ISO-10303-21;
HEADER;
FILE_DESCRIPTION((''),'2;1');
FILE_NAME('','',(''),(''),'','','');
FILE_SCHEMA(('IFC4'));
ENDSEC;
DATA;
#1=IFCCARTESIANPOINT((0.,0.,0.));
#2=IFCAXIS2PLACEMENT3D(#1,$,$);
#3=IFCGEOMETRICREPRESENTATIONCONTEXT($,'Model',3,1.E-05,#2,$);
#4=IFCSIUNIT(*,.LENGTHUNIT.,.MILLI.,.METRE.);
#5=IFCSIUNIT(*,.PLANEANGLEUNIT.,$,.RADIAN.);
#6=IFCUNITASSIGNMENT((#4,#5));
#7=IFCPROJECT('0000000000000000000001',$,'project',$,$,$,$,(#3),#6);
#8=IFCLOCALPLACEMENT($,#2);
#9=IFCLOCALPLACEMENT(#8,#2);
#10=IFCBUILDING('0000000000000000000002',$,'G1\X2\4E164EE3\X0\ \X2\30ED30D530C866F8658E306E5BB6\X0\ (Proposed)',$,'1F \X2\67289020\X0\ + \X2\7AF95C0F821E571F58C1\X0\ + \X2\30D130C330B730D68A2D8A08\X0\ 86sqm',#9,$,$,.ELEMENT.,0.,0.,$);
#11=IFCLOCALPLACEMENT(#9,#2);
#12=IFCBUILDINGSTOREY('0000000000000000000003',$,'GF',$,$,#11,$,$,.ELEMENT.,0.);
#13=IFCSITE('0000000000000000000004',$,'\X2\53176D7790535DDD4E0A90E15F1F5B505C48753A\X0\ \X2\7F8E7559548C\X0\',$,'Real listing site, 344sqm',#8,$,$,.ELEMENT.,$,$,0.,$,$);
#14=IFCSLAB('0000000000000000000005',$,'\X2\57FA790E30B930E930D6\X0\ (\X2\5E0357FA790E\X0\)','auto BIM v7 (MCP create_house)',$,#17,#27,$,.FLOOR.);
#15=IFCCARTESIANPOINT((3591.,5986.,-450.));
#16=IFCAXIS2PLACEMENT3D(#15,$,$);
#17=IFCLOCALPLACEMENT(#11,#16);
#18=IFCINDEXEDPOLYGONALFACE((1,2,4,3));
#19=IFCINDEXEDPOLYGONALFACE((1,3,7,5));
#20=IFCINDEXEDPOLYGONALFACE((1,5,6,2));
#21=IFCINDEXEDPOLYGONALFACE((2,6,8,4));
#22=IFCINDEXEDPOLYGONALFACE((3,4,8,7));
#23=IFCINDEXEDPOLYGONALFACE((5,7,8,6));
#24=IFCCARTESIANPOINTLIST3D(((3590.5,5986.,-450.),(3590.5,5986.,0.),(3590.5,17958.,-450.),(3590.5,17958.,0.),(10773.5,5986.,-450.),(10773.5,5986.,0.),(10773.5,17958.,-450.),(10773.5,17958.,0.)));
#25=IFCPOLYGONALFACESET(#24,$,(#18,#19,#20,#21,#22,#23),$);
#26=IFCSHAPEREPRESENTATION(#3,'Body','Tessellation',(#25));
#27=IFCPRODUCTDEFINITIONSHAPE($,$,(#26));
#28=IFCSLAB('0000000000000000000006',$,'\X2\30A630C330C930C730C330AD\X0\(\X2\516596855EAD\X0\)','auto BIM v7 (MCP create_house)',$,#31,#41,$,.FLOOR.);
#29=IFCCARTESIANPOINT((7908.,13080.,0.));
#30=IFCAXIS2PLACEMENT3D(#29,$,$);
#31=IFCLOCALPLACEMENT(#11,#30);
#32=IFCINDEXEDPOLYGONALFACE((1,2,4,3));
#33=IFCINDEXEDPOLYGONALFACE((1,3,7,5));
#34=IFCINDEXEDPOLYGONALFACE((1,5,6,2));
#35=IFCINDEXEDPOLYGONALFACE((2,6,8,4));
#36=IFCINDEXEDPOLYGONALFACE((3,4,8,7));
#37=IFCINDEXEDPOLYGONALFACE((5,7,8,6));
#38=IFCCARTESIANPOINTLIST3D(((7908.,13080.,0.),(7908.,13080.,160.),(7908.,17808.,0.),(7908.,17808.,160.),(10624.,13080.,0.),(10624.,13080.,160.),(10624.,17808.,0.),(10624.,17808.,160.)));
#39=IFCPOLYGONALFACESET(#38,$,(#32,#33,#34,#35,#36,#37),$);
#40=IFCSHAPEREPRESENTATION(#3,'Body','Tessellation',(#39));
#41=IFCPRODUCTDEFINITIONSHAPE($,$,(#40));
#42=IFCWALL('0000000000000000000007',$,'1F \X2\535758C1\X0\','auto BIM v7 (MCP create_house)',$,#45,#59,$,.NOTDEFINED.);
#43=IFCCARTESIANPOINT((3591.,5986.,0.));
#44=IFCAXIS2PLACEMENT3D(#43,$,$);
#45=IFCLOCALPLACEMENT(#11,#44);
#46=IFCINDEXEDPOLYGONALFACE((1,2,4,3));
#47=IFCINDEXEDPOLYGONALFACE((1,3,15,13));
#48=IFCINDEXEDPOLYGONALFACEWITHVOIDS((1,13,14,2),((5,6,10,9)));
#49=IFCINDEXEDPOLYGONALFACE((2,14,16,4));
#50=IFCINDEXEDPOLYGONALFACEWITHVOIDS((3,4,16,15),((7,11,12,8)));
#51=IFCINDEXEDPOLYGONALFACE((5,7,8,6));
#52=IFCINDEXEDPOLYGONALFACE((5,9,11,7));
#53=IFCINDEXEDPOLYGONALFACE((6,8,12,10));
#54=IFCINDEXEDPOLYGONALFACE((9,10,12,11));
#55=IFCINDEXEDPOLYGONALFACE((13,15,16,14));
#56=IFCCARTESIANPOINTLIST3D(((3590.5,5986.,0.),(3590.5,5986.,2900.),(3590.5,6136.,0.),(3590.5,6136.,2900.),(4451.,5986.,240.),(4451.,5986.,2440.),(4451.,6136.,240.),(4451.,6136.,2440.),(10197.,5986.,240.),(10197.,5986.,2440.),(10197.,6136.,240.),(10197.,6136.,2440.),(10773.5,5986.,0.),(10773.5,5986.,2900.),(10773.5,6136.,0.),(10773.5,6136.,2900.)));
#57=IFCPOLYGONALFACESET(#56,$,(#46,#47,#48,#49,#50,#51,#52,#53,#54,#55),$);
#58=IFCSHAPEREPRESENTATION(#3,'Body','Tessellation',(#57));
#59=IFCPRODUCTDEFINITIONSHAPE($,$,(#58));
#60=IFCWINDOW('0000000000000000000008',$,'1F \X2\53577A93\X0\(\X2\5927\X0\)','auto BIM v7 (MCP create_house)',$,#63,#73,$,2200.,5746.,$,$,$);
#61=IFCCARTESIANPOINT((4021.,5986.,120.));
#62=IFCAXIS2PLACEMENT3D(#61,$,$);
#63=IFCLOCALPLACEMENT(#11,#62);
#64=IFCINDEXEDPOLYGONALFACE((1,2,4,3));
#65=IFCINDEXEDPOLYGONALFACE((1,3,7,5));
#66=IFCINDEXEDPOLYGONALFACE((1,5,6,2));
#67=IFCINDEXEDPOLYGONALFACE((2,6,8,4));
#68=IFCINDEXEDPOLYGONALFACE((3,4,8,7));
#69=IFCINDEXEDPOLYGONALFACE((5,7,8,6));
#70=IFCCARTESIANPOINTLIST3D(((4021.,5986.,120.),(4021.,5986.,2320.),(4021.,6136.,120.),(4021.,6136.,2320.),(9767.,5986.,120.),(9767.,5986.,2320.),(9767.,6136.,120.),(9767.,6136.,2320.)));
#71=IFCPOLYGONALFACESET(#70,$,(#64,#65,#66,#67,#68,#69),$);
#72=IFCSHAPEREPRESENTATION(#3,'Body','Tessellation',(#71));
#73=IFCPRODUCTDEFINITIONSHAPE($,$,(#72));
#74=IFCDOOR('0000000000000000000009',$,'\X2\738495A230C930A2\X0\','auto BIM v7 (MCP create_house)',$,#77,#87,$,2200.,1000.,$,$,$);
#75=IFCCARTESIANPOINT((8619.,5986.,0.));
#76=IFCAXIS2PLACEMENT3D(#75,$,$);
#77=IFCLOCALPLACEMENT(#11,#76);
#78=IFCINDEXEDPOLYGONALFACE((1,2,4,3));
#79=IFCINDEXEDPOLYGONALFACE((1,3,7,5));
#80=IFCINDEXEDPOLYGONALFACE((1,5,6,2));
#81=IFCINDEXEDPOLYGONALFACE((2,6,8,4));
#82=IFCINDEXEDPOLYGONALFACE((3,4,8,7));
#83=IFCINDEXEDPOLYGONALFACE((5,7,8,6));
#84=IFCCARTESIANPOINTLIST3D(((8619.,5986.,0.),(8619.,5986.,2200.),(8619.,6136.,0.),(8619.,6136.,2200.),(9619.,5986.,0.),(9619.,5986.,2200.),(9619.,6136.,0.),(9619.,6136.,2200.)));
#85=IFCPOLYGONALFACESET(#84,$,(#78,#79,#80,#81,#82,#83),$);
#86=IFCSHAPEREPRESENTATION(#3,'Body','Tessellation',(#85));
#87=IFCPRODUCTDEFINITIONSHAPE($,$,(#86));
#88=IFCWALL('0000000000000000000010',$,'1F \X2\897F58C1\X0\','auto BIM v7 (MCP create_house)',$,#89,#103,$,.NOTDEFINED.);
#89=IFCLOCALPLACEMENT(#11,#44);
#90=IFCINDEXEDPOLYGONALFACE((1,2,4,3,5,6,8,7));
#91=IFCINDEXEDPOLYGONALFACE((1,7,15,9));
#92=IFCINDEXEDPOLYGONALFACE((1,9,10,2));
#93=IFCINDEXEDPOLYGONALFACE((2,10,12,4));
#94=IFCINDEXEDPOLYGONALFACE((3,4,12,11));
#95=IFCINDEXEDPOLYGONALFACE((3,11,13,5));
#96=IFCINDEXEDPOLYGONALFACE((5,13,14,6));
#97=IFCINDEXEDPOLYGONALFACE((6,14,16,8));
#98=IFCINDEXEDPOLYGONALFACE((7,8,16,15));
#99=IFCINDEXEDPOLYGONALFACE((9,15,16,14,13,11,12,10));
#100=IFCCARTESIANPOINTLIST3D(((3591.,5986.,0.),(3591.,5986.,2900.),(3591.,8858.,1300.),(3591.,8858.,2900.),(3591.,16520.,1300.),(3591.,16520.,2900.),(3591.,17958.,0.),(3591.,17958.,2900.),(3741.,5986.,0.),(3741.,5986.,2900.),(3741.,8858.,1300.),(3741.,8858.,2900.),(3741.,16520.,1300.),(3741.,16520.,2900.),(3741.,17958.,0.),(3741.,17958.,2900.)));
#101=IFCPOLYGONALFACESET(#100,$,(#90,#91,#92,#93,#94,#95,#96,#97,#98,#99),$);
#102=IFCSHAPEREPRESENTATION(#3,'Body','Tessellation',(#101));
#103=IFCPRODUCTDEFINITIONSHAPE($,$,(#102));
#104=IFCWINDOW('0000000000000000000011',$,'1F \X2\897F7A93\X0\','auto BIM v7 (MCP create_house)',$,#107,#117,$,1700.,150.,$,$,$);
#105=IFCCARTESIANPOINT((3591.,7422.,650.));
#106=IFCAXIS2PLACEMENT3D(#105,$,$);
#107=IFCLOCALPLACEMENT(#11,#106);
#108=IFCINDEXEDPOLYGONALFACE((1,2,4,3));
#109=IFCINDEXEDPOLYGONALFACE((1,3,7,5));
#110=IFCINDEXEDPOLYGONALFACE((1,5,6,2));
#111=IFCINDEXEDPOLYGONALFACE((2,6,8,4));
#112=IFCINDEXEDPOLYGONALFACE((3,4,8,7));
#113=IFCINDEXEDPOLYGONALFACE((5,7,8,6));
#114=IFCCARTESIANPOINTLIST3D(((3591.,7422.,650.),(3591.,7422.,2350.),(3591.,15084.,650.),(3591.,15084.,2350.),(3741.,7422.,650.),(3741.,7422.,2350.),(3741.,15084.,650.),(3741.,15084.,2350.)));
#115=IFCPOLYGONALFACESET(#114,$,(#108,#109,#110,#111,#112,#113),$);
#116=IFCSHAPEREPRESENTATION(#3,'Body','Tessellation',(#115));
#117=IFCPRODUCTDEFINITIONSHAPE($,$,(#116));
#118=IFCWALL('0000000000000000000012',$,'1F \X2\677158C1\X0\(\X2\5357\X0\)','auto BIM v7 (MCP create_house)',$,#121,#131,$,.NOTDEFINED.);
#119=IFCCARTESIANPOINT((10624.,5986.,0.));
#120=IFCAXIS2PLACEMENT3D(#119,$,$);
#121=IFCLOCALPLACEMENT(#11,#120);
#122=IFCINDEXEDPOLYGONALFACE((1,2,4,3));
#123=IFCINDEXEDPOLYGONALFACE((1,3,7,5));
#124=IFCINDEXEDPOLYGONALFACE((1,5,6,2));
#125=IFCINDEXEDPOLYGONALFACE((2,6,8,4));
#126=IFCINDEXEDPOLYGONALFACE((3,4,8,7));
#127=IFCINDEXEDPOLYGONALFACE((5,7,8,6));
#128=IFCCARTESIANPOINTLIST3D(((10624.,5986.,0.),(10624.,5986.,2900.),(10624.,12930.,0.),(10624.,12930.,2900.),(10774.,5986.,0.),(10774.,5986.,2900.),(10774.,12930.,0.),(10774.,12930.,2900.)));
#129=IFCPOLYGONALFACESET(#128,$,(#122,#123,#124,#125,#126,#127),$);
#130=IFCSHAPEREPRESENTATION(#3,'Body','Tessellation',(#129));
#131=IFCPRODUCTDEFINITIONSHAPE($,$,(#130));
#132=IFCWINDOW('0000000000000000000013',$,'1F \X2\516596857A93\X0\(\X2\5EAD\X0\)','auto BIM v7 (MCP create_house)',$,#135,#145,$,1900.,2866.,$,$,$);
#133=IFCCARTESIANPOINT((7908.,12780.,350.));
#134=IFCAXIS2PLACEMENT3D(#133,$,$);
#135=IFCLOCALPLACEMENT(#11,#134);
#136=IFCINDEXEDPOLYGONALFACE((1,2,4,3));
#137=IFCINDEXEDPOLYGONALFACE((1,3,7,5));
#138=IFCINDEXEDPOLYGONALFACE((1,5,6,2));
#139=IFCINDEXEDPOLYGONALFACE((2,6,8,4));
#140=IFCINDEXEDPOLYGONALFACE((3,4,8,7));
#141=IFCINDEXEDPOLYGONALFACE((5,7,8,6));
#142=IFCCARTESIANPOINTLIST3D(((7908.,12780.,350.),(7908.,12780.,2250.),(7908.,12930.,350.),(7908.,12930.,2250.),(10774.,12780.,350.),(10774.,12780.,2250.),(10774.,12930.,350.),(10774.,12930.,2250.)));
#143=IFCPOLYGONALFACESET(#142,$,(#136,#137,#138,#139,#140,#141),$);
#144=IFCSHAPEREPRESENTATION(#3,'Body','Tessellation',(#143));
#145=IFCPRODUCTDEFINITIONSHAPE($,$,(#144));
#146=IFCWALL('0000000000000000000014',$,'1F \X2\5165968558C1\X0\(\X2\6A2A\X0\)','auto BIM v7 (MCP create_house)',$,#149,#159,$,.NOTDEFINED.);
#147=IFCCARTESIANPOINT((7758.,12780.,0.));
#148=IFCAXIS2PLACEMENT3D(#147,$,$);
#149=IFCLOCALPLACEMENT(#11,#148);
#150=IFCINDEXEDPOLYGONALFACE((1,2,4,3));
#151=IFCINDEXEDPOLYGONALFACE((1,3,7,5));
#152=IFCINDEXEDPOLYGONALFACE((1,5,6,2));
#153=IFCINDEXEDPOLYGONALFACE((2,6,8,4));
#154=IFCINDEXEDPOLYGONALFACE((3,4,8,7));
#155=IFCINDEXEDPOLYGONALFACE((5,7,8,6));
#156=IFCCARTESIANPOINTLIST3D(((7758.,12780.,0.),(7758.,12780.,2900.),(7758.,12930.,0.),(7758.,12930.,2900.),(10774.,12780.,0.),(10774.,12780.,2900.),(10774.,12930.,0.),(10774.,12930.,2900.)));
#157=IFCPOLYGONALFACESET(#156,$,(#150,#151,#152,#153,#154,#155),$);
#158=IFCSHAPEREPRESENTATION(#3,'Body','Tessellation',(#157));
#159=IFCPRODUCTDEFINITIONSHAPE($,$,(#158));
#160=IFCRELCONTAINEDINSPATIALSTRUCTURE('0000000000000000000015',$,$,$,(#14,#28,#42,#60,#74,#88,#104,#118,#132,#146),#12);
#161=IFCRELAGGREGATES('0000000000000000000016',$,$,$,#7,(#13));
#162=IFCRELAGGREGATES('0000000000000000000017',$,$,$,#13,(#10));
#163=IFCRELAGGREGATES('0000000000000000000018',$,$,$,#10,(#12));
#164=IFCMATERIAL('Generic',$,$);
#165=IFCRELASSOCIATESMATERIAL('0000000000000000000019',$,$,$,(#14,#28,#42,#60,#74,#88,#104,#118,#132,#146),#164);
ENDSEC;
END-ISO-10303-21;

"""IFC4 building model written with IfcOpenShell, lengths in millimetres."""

from ifc_helpers import new_model, si_unit, frame, frame_2d, origin, place, context, project, spatial, rectangle, extrude, material, element, fill, save


model = new_model("IFC4")

# Units and contexts
model_context = context("Model", 3, precision=1e-05, world=origin())
ifc_project = project(units=[si_unit("LENGTHUNIT", "METRE", prefix="MILLI"), si_unit("PLANEANGLEUNIT", "RADIAN")], contexts=[model_context])

# Site, building, storey
site_placement = place(None, origin())
site = spatial("IfcSite", under=ifc_project, at=site_placement, Name="北海道川上郡弟子屈町 美留和", ObjectType="Real listing site, 344sqm", CompositionType="ELEMENT", RefElevation=0.0)
building_placement = place(site_placement, origin())
building = spatial("IfcBuilding", under=site, at=building_placement, Name="G1世代 ロフト書斎の家 (Proposed)", ObjectType="1F 木造 + 竹小舞土壁 + パッシブ設計 86sqm", CompositionType="ELEMENT", ElevationOfRefHeight=0.0, ElevationOfTerrain=0.0)
storey_placement = place(building_placement, origin())
storey = spatial("IfcBuildingStorey", under=building, at=storey_placement, Name="GF", CompositionType="ELEMENT", Elevation=0.0)

# Slabs
ifc_material = material(Name="Generic")
slab_1_placement = place(storey_placement, frame((3591.0, 5986.0, -450.0)))
element("IfcSlab", 1, at=slab_1_placement, inside=storey, material=ifc_material, Name="基礎スラブ (布基礎)", Description="auto BIM v7 (MCP create_house)", PredefinedType="FLOOR", context=model_context, shape_type="SweptSolid", body=[
    extrude(rectangle(XDim=7183.0, YDim=11972.0, at=frame_2d((3591.0, 5986.0))), frame((3591.0, 5986.0, -450.0)), (0.0, 0.0, 1.0), 450.0),
])
slab_2_placement = place(storey_placement, frame((7908.0, 13080.0, 0.0)))
element("IfcSlab", 2, at=slab_2_placement, inside=storey, material=ifc_material, Name="ウッドデッキ(入隅庭)", Description="auto BIM v7 (MCP create_house)", PredefinedType="FLOOR", context=model_context, shape_type="SweptSolid", body=[
    extrude(rectangle(XDim=2716.0, YDim=4728.0, at=frame_2d((1358.0, 2364.0))), frame((7908.0, 13080.0, 0.0)), (0.0, 0.0, 1.0), 160.0),
])

# Wall, openings, window, door
wall_1_placement = place(storey_placement, frame((3591.0, 5986.0, 0.0)))
wall_1 = element("IfcWall", 3, at=wall_1_placement, inside=storey, material=ifc_material, Name="1F 南壁", Description="auto BIM v7 (MCP create_house)", PredefinedType="NOTDEFINED", context=model_context, shape_type="SweptSolid", body=[
    extrude(rectangle(XDim=7183.0, YDim=150.0, at=frame_2d((3591.0, 75.0))), frame((3591.0, 5986.0, 0.0)), (0.0, 0.0, 1.0), 2900.0),
])
opening_1_placement = place(storey_placement, frame((4021.0, 5986.0, 120.0)))
opening_1 = element("IfcOpeningElement", 4, at=opening_1_placement, cuts=wall_1, PredefinedType="NOTDEFINED", context=model_context, shape_type="SweptSolid", body=[
    extrude(rectangle(XDim=5746.0, YDim=150.0, at=frame_2d((2873.0, 75.0))), frame((4021.0, 5986.0, 120.0)), (0.0, 0.0, 1.0), 2200.0),
])
opening_2_placement = place(storey_placement, frame((8619.0, 5986.0, 0.0)))
opening_2 = element("IfcOpeningElement", 5, at=opening_2_placement, cuts=wall_1, PredefinedType="NOTDEFINED", context=model_context, shape_type="SweptSolid", body=[
    extrude(rectangle(XDim=1000.0, YDim=150.0, at=frame_2d((500.0, 75.0))), frame((8619.0, 5986.0, 0.0)), (0.0, 0.0, 1.0), 2200.0),
])
window_1_placement = place(storey_placement, frame((4021.0, 5986.0, 120.0)))
window_1 = element("IfcWindow", 6, at=window_1_placement, inside=storey, material=ifc_material, Name="1F 南窓(大)", Description="auto BIM v7 (MCP create_house)", OverallHeight=2200.0, OverallWidth=5746.0, context=model_context, shape_type="SweptSolid", body=[
    extrude(rectangle(XDim=5746.0, YDim=150.0, at=frame_2d((2873.0, 75.0))), frame((4021.0, 5986.0, 120.0)), (0.0, 0.0, 1.0), 2200.0),
])
fill(opening_1, window_1)
door_placement = place(storey_placement, frame((8619.0, 5986.0, 0.0)))
door = element("IfcDoor", 7, at=door_placement, inside=storey, material=ifc_material, Name="玄関ドア", Description="auto BIM v7 (MCP create_house)", OverallHeight=2200.0, OverallWidth=1000.0, context=model_context, shape_type="SweptSolid", body=[
    extrude(rectangle(XDim=1000.0, YDim=150.0, at=frame_2d((500.0, 75.0))), frame((8619.0, 5986.0, 0.0)), (0.0, 0.0, 1.0), 2200.0),
])
fill(opening_2, door)

# Wall, opening, window
wall_2_placement = place(storey_placement, frame((3591.0, 5986.0, 0.0)))
wall_2 = element("IfcWall", 8, at=wall_2_placement, inside=storey, material=ifc_material, Name="1F 西壁", Description="auto BIM v7 (MCP create_house)", PredefinedType="NOTDEFINED", context=model_context, shape_type="SweptSolid", body=[
    extrude(rectangle(XDim=150.0, YDim=11972.0, at=frame_2d((75.0, 5986.0))), frame((3591.0, 5986.0, 0.0)), (0.0, 0.0, 1.0), 2900.0),
])
opening_3_placement = place(storey_placement, frame((3591.0, 7422.0, 650.0)))
opening_3 = element("IfcOpeningElement", 9, at=opening_3_placement, cuts=wall_2, PredefinedType="NOTDEFINED", context=model_context, shape_type="SweptSolid", body=[
    extrude(rectangle(XDim=150.0, YDim=7662.0, at=frame_2d((75.0, 3831.0))), frame((3591.0, 7422.0, 650.0)), (0.0, 0.0, 1.0), 1700.0),
])
window_2_placement = place(storey_placement, frame((3591.0, 7422.0, 650.0)))
window_2 = element("IfcWindow", 10, at=window_2_placement, inside=storey, material=ifc_material, Name="1F 西窓", Description="auto BIM v7 (MCP create_house)", OverallHeight=1700.0, OverallWidth=150.0, context=model_context, shape_type="SweptSolid", body=[
    extrude(rectangle(XDim=150.0, YDim=7662.0, at=frame_2d((75.0, 3831.0))), frame((3591.0, 7422.0, 650.0)), (0.0, 0.0, 1.0), 1700.0),
])
fill(opening_3, window_2)

# Wall, opening, window
wall_3_placement = place(storey_placement, frame((10624.0, 5986.0, 0.0)))
wall_3 = element("IfcWall", 11, at=wall_3_placement, inside=storey, material=ifc_material, Name="1F 東壁(南)", Description="auto BIM v7 (MCP create_house)", PredefinedType="NOTDEFINED", context=model_context, shape_type="SweptSolid", body=[
    extrude(rectangle(XDim=150.0, YDim=6944.0, at=frame_2d((75.0, 3472.0))), frame((10624.0, 5986.0, 0.0)), (0.0, 0.0, 1.0), 2900.0),
])
opening_4_placement = place(storey_placement, frame((7908.0, 12780.0, 350.0)))
opening_4 = element("IfcOpeningElement", 12, at=opening_4_placement, cuts=wall_3, PredefinedType="NOTDEFINED", context=model_context, shape_type="SweptSolid", body=[
    extrude(rectangle(XDim=2866.0, YDim=150.0, at=frame_2d((1433.0, 75.0))), frame((7908.0, 12780.0, 350.0)), (0.0, 0.0, 1.0), 1900.0),
])
window_3_placement = place(storey_placement, frame((7908.0, 12780.0, 350.0)))
window_3 = element("IfcWindow", 13, at=window_3_placement, inside=storey, material=ifc_material, Name="1F 入隅窓(庭)", Description="auto BIM v7 (MCP create_house)", OverallHeight=1900.0, OverallWidth=2866.0, context=model_context, shape_type="SweptSolid", body=[
    extrude(rectangle(XDim=2866.0, YDim=150.0, at=frame_2d((1433.0, 75.0))), frame((7908.0, 12780.0, 350.0)), (0.0, 0.0, 1.0), 1900.0),
])
fill(opening_4, window_3)

# Wall
wall_4_placement = place(storey_placement, frame((7758.0, 12780.0, 0.0)))
element("IfcWall", 14, at=wall_4_placement, inside=storey, material=ifc_material, Name="1F 入隅壁(横)", Description="auto BIM v7 (MCP create_house)", PredefinedType="NOTDEFINED", context=model_context, shape_type="SweptSolid", body=[
    extrude(rectangle(XDim=3016.0, YDim=150.0, at=frame_2d((1508.0, 75.0))), frame((7758.0, 12780.0, 0.0)), (0.0, 0.0, 1.0), 2900.0),
])

save(model, "model.ifc")
